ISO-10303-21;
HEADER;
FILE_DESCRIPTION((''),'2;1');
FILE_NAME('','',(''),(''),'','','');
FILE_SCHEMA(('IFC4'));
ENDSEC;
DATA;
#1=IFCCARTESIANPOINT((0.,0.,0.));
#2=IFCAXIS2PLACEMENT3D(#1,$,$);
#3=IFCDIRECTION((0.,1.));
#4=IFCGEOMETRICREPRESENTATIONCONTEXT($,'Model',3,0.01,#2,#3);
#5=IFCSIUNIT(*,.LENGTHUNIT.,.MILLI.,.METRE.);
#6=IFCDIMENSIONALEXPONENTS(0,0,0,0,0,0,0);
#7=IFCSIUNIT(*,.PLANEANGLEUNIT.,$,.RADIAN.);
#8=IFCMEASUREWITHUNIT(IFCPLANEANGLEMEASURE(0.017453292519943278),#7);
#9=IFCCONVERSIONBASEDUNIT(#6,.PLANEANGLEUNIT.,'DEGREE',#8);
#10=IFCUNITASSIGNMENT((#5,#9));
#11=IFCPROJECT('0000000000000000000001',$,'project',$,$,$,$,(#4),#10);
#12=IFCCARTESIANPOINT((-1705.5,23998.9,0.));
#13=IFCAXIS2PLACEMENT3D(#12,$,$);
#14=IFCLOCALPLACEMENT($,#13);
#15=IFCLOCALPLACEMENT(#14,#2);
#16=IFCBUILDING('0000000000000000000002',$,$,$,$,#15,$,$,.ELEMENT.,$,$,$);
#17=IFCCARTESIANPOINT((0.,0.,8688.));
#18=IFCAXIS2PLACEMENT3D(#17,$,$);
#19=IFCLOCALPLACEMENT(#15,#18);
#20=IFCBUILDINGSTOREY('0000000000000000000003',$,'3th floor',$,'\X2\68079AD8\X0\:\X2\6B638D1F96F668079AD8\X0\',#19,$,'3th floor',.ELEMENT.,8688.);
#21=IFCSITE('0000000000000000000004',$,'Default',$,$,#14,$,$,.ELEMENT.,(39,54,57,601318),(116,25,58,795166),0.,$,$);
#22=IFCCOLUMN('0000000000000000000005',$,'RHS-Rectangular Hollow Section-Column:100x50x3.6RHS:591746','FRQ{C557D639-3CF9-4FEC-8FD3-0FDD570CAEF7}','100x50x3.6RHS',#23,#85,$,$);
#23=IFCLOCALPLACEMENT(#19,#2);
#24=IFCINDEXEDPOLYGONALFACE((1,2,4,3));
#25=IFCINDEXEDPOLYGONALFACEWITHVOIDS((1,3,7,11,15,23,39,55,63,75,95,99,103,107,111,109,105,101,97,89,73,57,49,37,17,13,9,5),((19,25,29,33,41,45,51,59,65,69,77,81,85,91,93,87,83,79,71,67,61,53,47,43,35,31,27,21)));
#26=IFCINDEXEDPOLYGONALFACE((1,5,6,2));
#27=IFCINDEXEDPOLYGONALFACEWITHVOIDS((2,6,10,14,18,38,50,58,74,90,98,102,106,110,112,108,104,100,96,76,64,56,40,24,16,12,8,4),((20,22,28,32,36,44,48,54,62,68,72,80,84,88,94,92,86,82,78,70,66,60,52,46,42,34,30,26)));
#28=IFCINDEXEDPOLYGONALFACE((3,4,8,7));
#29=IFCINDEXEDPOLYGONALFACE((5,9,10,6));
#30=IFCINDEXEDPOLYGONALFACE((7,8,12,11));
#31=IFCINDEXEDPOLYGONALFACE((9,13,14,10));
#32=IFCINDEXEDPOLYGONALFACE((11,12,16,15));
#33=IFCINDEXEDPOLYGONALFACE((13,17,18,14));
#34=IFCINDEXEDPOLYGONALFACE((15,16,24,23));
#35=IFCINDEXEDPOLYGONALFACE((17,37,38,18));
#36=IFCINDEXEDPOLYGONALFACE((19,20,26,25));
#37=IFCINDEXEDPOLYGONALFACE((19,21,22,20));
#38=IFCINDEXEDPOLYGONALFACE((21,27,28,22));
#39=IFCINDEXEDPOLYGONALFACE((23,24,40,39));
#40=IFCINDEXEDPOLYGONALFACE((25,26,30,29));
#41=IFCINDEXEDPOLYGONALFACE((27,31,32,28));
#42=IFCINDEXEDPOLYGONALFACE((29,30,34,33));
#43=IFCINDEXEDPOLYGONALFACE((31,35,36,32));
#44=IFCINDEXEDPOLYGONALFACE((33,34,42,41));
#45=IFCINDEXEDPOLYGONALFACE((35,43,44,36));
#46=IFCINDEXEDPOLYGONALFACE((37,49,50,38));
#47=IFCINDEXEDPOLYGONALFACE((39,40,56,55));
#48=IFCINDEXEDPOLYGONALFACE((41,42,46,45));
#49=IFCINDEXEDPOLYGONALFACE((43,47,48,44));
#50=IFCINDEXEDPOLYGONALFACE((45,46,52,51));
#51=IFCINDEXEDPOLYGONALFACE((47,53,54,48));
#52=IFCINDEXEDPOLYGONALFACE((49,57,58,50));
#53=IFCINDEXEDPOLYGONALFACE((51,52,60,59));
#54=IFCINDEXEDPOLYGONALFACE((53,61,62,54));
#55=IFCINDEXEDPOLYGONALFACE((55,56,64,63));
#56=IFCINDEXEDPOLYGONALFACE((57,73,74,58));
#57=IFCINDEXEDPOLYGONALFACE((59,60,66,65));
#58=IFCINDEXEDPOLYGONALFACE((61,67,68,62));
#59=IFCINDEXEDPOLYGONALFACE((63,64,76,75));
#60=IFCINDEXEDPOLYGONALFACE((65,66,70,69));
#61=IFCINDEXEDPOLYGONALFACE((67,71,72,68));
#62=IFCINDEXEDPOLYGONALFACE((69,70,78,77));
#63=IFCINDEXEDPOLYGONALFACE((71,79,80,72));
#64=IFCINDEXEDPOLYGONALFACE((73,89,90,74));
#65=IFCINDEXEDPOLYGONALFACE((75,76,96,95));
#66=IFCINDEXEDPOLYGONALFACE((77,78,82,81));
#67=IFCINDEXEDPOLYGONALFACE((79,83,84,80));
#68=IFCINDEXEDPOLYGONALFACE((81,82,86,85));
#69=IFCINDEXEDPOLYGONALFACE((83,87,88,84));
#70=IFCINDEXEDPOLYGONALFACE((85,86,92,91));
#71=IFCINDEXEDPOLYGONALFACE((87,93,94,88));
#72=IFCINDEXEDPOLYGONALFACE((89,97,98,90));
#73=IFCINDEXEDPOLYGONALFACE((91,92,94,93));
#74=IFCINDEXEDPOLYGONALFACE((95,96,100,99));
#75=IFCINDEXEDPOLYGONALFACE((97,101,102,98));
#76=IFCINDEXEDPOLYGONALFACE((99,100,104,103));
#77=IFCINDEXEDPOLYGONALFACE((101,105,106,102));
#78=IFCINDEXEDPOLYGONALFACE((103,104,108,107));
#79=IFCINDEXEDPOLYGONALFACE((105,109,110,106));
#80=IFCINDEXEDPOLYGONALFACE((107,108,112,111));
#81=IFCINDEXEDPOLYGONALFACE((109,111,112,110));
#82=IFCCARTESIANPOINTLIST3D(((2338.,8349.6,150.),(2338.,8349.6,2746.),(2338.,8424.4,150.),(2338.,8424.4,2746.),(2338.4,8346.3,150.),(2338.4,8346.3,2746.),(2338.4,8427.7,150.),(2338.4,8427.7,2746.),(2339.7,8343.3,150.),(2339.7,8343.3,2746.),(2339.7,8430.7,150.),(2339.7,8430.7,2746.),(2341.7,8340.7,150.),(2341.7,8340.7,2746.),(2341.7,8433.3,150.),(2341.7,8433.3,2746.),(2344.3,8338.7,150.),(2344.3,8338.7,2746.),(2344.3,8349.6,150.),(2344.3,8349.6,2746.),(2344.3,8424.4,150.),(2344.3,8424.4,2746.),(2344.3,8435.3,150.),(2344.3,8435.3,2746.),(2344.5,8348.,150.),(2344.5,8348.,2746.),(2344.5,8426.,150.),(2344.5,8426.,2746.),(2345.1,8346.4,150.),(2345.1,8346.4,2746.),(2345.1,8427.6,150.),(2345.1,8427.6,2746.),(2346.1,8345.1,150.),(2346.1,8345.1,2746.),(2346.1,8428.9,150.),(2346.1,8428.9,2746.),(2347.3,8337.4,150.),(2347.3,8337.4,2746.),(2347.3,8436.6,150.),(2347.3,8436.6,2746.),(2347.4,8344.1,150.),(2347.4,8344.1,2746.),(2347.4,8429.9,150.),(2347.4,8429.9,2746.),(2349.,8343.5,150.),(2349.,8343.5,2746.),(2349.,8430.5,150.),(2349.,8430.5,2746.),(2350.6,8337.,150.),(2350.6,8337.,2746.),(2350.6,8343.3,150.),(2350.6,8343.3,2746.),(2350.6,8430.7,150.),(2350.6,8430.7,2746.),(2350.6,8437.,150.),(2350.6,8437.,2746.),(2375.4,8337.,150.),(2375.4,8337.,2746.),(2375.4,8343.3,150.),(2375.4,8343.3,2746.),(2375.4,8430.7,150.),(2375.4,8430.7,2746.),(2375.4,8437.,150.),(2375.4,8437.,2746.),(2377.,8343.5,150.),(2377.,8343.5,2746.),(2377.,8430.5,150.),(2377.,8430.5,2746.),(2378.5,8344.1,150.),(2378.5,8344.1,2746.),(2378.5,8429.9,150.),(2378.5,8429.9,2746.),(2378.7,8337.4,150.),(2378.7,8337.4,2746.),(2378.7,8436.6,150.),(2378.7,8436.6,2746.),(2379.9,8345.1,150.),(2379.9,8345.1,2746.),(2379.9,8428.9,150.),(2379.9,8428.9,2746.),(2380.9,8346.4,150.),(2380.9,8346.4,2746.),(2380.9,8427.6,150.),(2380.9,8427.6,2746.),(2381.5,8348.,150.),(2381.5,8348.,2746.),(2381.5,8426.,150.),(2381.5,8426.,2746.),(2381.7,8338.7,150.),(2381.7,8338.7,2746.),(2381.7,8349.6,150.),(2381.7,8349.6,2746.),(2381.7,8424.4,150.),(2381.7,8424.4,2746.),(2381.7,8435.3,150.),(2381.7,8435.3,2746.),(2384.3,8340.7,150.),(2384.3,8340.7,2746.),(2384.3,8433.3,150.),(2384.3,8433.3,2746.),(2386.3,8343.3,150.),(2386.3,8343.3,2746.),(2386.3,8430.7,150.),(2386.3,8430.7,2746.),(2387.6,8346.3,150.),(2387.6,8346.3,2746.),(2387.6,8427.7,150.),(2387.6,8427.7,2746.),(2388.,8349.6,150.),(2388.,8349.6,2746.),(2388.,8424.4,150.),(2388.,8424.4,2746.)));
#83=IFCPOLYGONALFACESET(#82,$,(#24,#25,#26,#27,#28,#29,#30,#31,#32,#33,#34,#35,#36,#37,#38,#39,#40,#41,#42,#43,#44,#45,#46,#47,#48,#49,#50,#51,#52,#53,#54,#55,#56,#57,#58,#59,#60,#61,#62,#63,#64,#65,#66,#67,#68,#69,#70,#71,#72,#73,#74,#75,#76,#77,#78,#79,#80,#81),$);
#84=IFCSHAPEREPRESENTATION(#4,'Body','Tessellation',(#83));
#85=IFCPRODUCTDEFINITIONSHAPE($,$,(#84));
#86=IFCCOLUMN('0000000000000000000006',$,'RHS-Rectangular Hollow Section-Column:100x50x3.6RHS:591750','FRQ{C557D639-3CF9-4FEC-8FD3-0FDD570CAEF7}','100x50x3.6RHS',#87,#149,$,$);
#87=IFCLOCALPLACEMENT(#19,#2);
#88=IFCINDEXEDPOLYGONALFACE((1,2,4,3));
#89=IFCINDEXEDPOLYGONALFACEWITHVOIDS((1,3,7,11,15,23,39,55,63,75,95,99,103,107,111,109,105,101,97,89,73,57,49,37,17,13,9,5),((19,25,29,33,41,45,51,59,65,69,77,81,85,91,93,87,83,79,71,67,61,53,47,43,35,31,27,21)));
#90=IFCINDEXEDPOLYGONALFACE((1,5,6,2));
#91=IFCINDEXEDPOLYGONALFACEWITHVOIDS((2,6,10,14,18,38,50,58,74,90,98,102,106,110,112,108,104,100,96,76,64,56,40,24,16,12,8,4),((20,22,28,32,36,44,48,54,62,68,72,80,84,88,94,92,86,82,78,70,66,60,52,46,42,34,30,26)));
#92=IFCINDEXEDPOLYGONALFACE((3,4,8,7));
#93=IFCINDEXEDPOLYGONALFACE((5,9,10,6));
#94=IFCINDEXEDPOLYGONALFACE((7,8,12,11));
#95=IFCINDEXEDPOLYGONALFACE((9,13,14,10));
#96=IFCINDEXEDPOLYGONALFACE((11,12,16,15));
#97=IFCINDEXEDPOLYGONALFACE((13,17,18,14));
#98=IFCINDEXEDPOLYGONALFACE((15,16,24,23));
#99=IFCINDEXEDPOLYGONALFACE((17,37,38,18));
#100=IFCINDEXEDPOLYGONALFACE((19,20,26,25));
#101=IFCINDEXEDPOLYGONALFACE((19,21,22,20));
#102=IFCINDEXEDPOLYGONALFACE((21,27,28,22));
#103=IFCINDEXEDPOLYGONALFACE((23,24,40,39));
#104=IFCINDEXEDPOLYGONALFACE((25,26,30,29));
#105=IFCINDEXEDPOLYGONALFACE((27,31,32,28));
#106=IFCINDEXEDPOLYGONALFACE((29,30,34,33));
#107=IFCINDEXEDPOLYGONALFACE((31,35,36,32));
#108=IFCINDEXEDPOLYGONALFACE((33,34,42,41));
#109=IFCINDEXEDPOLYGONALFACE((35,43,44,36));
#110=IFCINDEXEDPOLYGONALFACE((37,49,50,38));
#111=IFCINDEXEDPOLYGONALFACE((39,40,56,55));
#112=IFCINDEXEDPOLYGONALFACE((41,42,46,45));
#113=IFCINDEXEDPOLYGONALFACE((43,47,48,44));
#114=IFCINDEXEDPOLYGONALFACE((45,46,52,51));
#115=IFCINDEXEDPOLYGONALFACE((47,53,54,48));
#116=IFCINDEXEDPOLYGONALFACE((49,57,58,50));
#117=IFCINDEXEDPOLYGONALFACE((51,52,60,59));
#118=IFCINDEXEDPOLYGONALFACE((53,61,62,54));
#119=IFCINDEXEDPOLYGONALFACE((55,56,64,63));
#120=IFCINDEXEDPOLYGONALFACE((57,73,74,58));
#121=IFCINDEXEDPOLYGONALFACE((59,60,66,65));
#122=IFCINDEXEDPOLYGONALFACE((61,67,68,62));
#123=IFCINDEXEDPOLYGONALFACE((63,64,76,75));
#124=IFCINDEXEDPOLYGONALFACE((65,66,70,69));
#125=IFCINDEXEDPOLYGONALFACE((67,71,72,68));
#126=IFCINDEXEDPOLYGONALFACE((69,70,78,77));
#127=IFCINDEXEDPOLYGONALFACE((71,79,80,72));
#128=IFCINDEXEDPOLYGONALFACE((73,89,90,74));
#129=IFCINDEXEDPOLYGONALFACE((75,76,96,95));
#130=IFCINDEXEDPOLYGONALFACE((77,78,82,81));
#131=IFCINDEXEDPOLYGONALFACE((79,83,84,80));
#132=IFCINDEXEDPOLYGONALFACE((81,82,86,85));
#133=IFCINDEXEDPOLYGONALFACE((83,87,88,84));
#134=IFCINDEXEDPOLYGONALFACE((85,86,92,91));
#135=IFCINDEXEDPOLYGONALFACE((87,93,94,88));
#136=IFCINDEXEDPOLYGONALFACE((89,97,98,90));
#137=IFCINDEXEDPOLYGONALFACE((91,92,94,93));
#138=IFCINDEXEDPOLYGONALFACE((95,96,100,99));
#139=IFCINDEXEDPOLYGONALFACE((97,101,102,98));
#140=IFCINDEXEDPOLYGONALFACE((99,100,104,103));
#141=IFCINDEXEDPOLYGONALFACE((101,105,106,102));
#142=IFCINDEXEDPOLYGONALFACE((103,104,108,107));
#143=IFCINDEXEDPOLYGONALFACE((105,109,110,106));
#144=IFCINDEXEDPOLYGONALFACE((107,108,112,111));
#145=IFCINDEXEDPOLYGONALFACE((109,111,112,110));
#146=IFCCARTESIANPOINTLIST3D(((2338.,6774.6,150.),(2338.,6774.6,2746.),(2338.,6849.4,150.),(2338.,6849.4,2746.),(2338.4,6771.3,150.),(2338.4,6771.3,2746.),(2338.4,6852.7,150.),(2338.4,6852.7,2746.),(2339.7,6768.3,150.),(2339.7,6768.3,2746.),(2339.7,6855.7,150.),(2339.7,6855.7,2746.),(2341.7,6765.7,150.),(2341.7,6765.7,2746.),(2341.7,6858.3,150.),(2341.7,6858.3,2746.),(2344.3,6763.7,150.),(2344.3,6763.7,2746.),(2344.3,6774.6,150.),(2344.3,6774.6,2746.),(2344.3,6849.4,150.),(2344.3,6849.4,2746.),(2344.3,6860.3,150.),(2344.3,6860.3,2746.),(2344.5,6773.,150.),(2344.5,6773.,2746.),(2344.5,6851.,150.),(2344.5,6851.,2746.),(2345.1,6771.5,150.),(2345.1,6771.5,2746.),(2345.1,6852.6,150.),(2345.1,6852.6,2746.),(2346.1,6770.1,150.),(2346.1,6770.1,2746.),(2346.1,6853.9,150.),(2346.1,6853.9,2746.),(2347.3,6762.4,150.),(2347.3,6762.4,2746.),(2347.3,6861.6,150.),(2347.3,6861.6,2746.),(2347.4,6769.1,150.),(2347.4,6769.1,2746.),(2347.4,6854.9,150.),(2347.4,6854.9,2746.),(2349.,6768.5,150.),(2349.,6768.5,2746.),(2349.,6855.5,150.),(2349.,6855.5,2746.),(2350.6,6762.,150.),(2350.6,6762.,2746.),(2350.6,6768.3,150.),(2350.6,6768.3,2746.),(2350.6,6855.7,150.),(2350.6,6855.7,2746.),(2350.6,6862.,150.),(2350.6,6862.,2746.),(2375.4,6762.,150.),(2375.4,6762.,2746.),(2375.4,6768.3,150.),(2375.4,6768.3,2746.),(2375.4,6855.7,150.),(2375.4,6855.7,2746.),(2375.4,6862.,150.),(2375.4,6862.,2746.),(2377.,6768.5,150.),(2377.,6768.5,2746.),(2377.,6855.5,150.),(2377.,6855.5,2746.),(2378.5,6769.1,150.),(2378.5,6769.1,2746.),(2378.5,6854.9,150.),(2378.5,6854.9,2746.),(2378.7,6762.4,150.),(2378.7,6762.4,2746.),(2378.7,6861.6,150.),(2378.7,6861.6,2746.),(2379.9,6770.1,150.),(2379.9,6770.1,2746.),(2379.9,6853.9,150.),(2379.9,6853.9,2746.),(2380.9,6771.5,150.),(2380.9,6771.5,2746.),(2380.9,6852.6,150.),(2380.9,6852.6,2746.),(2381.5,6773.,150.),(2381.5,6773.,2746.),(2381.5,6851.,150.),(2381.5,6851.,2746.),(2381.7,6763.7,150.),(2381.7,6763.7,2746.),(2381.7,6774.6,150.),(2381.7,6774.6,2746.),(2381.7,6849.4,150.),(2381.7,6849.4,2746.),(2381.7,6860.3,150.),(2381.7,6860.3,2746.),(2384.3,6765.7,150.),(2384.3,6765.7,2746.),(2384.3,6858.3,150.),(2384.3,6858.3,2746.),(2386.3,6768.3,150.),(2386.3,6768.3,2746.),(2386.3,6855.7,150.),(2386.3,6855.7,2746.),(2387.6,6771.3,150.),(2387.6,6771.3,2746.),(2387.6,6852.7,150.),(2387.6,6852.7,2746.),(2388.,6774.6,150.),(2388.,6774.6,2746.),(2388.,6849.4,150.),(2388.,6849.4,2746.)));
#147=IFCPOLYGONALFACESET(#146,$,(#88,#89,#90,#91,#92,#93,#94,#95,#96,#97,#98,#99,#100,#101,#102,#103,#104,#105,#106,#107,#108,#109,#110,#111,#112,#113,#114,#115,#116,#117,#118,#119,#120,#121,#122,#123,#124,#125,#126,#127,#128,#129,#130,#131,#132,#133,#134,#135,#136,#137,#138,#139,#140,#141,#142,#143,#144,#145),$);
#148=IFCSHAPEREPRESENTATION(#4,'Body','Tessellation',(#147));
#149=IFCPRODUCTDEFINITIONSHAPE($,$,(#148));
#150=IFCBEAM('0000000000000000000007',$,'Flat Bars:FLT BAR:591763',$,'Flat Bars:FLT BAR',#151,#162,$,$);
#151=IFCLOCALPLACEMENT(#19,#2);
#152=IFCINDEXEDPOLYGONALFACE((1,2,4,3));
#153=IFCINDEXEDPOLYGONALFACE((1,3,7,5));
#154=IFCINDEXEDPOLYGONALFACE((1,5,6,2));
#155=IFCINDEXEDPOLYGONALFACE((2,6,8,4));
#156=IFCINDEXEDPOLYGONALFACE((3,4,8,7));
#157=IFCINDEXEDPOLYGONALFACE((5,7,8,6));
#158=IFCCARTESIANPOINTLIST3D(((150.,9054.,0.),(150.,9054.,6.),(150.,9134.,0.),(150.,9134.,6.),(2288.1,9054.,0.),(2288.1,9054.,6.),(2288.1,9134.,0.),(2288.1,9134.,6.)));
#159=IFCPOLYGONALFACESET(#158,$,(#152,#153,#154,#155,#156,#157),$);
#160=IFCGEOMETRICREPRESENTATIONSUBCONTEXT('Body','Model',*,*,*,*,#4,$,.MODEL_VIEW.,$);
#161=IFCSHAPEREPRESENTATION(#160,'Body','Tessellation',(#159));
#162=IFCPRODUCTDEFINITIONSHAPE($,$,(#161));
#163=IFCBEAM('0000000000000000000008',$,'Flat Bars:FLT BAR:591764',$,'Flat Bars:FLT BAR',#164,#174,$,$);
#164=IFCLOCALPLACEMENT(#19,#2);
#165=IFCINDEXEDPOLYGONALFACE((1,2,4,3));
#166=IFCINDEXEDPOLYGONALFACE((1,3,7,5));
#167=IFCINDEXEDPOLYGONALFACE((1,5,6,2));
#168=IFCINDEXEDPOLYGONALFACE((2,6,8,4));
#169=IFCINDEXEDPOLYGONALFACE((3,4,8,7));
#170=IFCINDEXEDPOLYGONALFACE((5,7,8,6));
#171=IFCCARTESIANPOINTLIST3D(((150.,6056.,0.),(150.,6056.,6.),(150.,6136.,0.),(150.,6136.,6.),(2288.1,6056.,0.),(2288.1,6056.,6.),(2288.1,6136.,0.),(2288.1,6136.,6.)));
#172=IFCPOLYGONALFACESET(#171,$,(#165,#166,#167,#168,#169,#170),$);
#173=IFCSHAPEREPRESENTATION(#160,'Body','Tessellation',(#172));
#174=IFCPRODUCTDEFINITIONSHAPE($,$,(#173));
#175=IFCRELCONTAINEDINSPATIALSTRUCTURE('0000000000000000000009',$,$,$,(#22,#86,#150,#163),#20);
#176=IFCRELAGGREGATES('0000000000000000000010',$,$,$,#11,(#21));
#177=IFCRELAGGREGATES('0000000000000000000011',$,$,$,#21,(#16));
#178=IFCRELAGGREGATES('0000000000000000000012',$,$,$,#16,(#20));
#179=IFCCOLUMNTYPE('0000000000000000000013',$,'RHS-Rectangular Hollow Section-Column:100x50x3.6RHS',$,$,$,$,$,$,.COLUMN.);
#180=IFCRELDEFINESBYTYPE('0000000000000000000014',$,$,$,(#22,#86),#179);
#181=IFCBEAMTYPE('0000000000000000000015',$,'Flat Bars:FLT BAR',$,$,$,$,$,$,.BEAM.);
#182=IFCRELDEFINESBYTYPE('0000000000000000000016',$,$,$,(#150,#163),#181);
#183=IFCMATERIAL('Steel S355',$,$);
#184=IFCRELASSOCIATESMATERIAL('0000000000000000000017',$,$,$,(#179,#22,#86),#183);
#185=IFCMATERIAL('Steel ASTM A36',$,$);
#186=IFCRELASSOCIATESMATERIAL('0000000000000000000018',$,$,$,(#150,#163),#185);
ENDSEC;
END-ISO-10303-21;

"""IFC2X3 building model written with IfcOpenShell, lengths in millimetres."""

from ifc_helpers import new_model, entity, si_unit, converted_unit, direction, frame, frame_2d, origin, origin_2d, place, context, subcontext, project, spatial, rectangle, hollow_rectangle, extrude, clip, halfspace, material, type_object, element, save


model = new_model("IFC2X3")

# Units and contexts
model_context = context("Model", 3, precision=0.01, world=origin(), true_north=direction((0.0, 1.0)))
body_context = subcontext(model_context, "Body", "Model", "MODEL_VIEW")
ifc_project = project(units=[si_unit("LENGTHUNIT", "METRE", prefix="MILLI"), converted_unit("PLANEANGLEUNIT", "DEGREE", entity("IfcPlaneAngleMeasure", 0.017453292519943278), si_unit("PLANEANGLEUNIT", "RADIAN"), dimensions=[0, 0, 0, 0, 0, 0, 0])], contexts=[model_context])

# Site, building, storey
site_placement = place(None, frame((-1705.5, 23998.9, 0.0)))
site = spatial("IfcSite", under=ifc_project, at=site_placement, Name="Default", CompositionType="ELEMENT", RefLatitude=(39, 54, 57, 601318), RefLongitude=(116, 25, 58, 795166), RefElevation=0.0)
building_placement = place(site_placement, origin())
building = spatial("IfcBuilding", under=site, at=building_placement, CompositionType="ELEMENT")
storey_placement = place(building_placement, frame((0.0, 0.0, 8688.0)))
storey = spatial("IfcBuildingStorey", under=building, at=storey_placement, Name="3th floor", ObjectType="标高:正负零标高", LongName="3th floor", CompositionType="ELEMENT", Elevation=8688.0)

# Shared definitions
ifc_material_1 = material(Name="Steel S355")

# Columns
column_type_1 = type_object("IfcColumnType", Name="RHS-Rectangular Hollow Section-Column:100x50x3.6RHS", PredefinedType="COLUMN", material=ifc_material_1)
column_1_placement = place(storey_placement, frame((2363.0, 8387.0, 2746.0), z_axis=(0.0, 0.0, 1.0), x_axis=(-1.0, 0.0, 0.0)))
element("IfcColumn", 1, at=column_1_placement, inside=storey, type_object=column_type_1, material=ifc_material_1, Name="RHS-Rectangular Hollow Section-Column:100x50x3.6RHS:591746", Description="FRQ{C557D639-3CF9-4FEC-8FD3-0FDD570CAEF7}", ObjectType="100x50x3.6RHS", context=model_context, shape_type="Clipping", body=[
    clip(extrude(hollow_rectangle(XDim=50.0, YDim=100.0, WallThickness=6.3, InnerFilletRadius=6.3, OuterFilletRadius=12.6, at=origin_2d()), origin(), (0.0, 0.0, -1.0), 2651.9), halfspace(frame((2363.0, 8387.0, -2596.0), z_axis=(0.0, 0.0, 1.0), x_axis=(-1.0, 0.0, 0.0)), True)),
])
column_2_placement = place(storey_placement, frame((2363.0, 6812.0, 2746.0), z_axis=(0.0, 0.0, 1.0), x_axis=(-1.0, 0.0, 0.0)))
element("IfcColumn", 2, at=column_2_placement, inside=storey, type_object=column_type_1, material=ifc_material_1, Name="RHS-Rectangular Hollow Section-Column:100x50x3.6RHS:591750", Description="FRQ{C557D639-3CF9-4FEC-8FD3-0FDD570CAEF7}", ObjectType="100x50x3.6RHS", context=model_context, shape_type="Clipping", body=[
    clip(extrude(hollow_rectangle(XDim=50.0, YDim=100.0, WallThickness=6.3, InnerFilletRadius=6.3, OuterFilletRadius=12.6, at=origin_2d()), origin(), (0.0, 0.0, -1.0), 2651.9), halfspace(frame((2363.0, 6812.0, -2596.0), z_axis=(0.0, 0.0, 1.0), x_axis=(-1.0, 0.0, 0.0)), True)),
])

# Beams
ifc_material_2 = material(Name="Steel ASTM A36")
beam_type = type_object("IfcBeamType", Name="Flat Bars:FLT BAR", PredefinedType="BEAM")
for number, where, name in (
    (3, (150.0, 9094.0, 6.0), "Flat Bars:FLT BAR:591763"),
    (4, (150.0, 6096.0, 6.0), "Flat Bars:FLT BAR:591764"),
):
    element("IfcBeam", number, at=place(storey_placement, frame(where)), inside=storey, type_object=beam_type, material=ifc_material_2, Name=name, ObjectType="Flat Bars:FLT BAR", context=body_context, shape_type="SweptSolid", body=[
        extrude(rectangle(XDim=6.0, YDim=80.0, at=frame_2d((0.0, 0.0), x_axis=(1.0, 0.0))), frame((0.0, 0.0, -3.0), z_axis=(1.0, 0.0, 0.0), x_axis=(0.0, 0.0, -1.0)), (0.0, 0.0, 1.0), 2138.1),
    ])

save(model, "model.ifc")
